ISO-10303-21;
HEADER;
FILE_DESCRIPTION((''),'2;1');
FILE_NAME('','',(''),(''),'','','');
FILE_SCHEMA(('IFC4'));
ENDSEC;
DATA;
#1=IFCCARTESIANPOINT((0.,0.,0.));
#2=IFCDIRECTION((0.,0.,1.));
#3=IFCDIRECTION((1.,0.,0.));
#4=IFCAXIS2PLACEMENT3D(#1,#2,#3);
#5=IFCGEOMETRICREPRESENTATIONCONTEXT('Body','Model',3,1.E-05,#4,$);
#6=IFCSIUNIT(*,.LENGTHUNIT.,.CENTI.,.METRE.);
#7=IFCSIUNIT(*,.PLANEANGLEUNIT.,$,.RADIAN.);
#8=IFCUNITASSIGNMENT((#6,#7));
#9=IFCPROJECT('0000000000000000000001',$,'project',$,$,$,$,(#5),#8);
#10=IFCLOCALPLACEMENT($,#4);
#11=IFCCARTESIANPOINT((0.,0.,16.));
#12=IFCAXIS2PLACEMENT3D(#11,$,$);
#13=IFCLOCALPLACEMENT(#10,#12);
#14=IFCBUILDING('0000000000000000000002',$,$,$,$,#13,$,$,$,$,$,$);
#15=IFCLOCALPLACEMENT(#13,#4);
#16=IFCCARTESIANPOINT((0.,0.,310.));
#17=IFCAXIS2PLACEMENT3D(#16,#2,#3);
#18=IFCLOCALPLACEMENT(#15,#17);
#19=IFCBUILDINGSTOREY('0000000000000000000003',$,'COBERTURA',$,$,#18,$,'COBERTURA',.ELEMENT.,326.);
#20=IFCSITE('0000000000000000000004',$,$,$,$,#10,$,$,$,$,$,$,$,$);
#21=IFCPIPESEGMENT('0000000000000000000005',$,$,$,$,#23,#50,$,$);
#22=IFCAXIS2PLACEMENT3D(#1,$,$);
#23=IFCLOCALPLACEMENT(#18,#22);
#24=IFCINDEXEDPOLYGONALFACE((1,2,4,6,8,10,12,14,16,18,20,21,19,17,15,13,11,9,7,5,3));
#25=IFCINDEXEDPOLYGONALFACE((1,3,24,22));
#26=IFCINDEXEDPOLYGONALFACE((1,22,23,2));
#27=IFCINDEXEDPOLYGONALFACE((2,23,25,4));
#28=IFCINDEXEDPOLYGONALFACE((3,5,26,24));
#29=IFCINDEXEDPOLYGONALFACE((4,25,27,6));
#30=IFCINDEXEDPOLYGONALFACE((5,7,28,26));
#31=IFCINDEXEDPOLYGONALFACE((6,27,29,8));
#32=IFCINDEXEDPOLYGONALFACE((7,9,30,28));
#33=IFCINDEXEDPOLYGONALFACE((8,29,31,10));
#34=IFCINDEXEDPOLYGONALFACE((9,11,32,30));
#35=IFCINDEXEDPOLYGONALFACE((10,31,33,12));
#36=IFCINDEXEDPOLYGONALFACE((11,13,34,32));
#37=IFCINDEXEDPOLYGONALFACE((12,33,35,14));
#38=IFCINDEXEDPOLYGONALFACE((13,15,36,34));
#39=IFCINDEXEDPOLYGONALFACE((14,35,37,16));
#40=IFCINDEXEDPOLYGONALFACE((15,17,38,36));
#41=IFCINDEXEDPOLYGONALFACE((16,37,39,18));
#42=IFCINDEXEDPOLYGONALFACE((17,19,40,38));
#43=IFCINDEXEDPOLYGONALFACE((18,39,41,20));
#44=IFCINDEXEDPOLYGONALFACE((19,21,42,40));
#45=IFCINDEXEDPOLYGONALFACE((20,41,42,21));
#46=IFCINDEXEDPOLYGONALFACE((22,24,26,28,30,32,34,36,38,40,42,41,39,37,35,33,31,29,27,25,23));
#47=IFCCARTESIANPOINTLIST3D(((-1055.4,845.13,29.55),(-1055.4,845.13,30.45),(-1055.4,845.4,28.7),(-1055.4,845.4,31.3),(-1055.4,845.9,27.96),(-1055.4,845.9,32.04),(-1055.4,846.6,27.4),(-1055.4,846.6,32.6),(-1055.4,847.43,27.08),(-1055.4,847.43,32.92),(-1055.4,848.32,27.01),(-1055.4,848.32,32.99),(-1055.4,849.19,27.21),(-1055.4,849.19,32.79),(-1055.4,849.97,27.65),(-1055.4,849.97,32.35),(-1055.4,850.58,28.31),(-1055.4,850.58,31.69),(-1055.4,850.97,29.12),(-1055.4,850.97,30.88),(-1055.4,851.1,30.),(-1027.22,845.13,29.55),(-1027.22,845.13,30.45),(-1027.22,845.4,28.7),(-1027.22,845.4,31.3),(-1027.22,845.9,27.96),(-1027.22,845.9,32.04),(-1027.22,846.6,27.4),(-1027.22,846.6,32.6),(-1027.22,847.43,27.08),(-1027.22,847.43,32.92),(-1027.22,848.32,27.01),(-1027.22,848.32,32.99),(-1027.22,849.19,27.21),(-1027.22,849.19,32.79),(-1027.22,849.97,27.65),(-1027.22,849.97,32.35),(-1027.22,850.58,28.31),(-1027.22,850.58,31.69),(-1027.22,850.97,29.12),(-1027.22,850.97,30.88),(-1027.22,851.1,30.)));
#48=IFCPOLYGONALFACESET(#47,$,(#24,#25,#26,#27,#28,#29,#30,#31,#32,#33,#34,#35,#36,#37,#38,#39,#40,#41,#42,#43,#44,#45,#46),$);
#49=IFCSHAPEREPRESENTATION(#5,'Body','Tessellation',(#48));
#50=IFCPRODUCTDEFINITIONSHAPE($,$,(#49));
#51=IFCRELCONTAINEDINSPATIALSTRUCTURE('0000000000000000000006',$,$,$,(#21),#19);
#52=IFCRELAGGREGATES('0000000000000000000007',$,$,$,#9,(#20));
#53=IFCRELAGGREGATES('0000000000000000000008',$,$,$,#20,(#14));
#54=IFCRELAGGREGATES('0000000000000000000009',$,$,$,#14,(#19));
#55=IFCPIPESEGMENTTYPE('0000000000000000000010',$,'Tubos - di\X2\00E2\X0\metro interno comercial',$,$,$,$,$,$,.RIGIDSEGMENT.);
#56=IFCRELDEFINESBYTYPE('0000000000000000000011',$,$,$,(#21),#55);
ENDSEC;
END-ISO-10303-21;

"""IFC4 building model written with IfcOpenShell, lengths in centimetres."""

from ifc_helpers import new_model, si_unit, frame, origin_with_axes, origin_2d_with_axis, place, context, project, spatial, circle, extrude, type_object, element, save


model = new_model("IFC4")

# Units and contexts
model_context = context("Model", 3, precision=1e-05, world=origin_with_axes(), identifier="Body")
ifc_project = project(units=[si_unit("LENGTHUNIT", "METRE", prefix="CENTI"), si_unit("PLANEANGLEUNIT", "RADIAN")], contexts=[model_context])

# Site, building, storey
site_placement = place(None, origin_with_axes())
site = spatial("IfcSite", under=ifc_project, at=site_placement)
building_placement = place(site_placement, frame((0.0, 0.0, 16.0)))
building = spatial("IfcBuilding", under=site, at=building_placement)
placement = place(building_placement, origin_with_axes())
storey_placement = place(placement, frame((0.0, 0.0, 310.0), z_axis=(0.0, 0.0, 1.0), x_axis=(1.0, 0.0, 0.0)))
storey = spatial("IfcBuildingStorey", under=building, at=storey_placement, Name="COBERTURA", LongName="COBERTURA", CompositionType="ELEMENT", Elevation=326.0)

# Pipe segment
pipe_segment_type = type_object("IfcPipeSegmentType", Name="Tubos - diâmetro interno comercial", PredefinedType="RIGIDSEGMENT")
pipe_segment_1_placement = place(storey_placement, frame((-1041.31, 848.1, 33.0), z_axis=(0.0, 0.0, 1.0), x_axis=(1.0, 0.0, 0.0)))
element("IfcPipeSegment", 1, at=pipe_segment_1_placement, inside=storey, type_object=pipe_segment_type, context=model_context, shape_type="SolidModel", body=[
    extrude(circle(Radius=3.0, at=origin_2d_with_axis()), frame((-14.09, 0.0, -3.0), z_axis=(1.0, 0.0, 0.0), x_axis=(0.0, 1.0, 0.0)), (0.0, 0.0, 1.0), 28.18),
])

save(model, "model.ifc")
